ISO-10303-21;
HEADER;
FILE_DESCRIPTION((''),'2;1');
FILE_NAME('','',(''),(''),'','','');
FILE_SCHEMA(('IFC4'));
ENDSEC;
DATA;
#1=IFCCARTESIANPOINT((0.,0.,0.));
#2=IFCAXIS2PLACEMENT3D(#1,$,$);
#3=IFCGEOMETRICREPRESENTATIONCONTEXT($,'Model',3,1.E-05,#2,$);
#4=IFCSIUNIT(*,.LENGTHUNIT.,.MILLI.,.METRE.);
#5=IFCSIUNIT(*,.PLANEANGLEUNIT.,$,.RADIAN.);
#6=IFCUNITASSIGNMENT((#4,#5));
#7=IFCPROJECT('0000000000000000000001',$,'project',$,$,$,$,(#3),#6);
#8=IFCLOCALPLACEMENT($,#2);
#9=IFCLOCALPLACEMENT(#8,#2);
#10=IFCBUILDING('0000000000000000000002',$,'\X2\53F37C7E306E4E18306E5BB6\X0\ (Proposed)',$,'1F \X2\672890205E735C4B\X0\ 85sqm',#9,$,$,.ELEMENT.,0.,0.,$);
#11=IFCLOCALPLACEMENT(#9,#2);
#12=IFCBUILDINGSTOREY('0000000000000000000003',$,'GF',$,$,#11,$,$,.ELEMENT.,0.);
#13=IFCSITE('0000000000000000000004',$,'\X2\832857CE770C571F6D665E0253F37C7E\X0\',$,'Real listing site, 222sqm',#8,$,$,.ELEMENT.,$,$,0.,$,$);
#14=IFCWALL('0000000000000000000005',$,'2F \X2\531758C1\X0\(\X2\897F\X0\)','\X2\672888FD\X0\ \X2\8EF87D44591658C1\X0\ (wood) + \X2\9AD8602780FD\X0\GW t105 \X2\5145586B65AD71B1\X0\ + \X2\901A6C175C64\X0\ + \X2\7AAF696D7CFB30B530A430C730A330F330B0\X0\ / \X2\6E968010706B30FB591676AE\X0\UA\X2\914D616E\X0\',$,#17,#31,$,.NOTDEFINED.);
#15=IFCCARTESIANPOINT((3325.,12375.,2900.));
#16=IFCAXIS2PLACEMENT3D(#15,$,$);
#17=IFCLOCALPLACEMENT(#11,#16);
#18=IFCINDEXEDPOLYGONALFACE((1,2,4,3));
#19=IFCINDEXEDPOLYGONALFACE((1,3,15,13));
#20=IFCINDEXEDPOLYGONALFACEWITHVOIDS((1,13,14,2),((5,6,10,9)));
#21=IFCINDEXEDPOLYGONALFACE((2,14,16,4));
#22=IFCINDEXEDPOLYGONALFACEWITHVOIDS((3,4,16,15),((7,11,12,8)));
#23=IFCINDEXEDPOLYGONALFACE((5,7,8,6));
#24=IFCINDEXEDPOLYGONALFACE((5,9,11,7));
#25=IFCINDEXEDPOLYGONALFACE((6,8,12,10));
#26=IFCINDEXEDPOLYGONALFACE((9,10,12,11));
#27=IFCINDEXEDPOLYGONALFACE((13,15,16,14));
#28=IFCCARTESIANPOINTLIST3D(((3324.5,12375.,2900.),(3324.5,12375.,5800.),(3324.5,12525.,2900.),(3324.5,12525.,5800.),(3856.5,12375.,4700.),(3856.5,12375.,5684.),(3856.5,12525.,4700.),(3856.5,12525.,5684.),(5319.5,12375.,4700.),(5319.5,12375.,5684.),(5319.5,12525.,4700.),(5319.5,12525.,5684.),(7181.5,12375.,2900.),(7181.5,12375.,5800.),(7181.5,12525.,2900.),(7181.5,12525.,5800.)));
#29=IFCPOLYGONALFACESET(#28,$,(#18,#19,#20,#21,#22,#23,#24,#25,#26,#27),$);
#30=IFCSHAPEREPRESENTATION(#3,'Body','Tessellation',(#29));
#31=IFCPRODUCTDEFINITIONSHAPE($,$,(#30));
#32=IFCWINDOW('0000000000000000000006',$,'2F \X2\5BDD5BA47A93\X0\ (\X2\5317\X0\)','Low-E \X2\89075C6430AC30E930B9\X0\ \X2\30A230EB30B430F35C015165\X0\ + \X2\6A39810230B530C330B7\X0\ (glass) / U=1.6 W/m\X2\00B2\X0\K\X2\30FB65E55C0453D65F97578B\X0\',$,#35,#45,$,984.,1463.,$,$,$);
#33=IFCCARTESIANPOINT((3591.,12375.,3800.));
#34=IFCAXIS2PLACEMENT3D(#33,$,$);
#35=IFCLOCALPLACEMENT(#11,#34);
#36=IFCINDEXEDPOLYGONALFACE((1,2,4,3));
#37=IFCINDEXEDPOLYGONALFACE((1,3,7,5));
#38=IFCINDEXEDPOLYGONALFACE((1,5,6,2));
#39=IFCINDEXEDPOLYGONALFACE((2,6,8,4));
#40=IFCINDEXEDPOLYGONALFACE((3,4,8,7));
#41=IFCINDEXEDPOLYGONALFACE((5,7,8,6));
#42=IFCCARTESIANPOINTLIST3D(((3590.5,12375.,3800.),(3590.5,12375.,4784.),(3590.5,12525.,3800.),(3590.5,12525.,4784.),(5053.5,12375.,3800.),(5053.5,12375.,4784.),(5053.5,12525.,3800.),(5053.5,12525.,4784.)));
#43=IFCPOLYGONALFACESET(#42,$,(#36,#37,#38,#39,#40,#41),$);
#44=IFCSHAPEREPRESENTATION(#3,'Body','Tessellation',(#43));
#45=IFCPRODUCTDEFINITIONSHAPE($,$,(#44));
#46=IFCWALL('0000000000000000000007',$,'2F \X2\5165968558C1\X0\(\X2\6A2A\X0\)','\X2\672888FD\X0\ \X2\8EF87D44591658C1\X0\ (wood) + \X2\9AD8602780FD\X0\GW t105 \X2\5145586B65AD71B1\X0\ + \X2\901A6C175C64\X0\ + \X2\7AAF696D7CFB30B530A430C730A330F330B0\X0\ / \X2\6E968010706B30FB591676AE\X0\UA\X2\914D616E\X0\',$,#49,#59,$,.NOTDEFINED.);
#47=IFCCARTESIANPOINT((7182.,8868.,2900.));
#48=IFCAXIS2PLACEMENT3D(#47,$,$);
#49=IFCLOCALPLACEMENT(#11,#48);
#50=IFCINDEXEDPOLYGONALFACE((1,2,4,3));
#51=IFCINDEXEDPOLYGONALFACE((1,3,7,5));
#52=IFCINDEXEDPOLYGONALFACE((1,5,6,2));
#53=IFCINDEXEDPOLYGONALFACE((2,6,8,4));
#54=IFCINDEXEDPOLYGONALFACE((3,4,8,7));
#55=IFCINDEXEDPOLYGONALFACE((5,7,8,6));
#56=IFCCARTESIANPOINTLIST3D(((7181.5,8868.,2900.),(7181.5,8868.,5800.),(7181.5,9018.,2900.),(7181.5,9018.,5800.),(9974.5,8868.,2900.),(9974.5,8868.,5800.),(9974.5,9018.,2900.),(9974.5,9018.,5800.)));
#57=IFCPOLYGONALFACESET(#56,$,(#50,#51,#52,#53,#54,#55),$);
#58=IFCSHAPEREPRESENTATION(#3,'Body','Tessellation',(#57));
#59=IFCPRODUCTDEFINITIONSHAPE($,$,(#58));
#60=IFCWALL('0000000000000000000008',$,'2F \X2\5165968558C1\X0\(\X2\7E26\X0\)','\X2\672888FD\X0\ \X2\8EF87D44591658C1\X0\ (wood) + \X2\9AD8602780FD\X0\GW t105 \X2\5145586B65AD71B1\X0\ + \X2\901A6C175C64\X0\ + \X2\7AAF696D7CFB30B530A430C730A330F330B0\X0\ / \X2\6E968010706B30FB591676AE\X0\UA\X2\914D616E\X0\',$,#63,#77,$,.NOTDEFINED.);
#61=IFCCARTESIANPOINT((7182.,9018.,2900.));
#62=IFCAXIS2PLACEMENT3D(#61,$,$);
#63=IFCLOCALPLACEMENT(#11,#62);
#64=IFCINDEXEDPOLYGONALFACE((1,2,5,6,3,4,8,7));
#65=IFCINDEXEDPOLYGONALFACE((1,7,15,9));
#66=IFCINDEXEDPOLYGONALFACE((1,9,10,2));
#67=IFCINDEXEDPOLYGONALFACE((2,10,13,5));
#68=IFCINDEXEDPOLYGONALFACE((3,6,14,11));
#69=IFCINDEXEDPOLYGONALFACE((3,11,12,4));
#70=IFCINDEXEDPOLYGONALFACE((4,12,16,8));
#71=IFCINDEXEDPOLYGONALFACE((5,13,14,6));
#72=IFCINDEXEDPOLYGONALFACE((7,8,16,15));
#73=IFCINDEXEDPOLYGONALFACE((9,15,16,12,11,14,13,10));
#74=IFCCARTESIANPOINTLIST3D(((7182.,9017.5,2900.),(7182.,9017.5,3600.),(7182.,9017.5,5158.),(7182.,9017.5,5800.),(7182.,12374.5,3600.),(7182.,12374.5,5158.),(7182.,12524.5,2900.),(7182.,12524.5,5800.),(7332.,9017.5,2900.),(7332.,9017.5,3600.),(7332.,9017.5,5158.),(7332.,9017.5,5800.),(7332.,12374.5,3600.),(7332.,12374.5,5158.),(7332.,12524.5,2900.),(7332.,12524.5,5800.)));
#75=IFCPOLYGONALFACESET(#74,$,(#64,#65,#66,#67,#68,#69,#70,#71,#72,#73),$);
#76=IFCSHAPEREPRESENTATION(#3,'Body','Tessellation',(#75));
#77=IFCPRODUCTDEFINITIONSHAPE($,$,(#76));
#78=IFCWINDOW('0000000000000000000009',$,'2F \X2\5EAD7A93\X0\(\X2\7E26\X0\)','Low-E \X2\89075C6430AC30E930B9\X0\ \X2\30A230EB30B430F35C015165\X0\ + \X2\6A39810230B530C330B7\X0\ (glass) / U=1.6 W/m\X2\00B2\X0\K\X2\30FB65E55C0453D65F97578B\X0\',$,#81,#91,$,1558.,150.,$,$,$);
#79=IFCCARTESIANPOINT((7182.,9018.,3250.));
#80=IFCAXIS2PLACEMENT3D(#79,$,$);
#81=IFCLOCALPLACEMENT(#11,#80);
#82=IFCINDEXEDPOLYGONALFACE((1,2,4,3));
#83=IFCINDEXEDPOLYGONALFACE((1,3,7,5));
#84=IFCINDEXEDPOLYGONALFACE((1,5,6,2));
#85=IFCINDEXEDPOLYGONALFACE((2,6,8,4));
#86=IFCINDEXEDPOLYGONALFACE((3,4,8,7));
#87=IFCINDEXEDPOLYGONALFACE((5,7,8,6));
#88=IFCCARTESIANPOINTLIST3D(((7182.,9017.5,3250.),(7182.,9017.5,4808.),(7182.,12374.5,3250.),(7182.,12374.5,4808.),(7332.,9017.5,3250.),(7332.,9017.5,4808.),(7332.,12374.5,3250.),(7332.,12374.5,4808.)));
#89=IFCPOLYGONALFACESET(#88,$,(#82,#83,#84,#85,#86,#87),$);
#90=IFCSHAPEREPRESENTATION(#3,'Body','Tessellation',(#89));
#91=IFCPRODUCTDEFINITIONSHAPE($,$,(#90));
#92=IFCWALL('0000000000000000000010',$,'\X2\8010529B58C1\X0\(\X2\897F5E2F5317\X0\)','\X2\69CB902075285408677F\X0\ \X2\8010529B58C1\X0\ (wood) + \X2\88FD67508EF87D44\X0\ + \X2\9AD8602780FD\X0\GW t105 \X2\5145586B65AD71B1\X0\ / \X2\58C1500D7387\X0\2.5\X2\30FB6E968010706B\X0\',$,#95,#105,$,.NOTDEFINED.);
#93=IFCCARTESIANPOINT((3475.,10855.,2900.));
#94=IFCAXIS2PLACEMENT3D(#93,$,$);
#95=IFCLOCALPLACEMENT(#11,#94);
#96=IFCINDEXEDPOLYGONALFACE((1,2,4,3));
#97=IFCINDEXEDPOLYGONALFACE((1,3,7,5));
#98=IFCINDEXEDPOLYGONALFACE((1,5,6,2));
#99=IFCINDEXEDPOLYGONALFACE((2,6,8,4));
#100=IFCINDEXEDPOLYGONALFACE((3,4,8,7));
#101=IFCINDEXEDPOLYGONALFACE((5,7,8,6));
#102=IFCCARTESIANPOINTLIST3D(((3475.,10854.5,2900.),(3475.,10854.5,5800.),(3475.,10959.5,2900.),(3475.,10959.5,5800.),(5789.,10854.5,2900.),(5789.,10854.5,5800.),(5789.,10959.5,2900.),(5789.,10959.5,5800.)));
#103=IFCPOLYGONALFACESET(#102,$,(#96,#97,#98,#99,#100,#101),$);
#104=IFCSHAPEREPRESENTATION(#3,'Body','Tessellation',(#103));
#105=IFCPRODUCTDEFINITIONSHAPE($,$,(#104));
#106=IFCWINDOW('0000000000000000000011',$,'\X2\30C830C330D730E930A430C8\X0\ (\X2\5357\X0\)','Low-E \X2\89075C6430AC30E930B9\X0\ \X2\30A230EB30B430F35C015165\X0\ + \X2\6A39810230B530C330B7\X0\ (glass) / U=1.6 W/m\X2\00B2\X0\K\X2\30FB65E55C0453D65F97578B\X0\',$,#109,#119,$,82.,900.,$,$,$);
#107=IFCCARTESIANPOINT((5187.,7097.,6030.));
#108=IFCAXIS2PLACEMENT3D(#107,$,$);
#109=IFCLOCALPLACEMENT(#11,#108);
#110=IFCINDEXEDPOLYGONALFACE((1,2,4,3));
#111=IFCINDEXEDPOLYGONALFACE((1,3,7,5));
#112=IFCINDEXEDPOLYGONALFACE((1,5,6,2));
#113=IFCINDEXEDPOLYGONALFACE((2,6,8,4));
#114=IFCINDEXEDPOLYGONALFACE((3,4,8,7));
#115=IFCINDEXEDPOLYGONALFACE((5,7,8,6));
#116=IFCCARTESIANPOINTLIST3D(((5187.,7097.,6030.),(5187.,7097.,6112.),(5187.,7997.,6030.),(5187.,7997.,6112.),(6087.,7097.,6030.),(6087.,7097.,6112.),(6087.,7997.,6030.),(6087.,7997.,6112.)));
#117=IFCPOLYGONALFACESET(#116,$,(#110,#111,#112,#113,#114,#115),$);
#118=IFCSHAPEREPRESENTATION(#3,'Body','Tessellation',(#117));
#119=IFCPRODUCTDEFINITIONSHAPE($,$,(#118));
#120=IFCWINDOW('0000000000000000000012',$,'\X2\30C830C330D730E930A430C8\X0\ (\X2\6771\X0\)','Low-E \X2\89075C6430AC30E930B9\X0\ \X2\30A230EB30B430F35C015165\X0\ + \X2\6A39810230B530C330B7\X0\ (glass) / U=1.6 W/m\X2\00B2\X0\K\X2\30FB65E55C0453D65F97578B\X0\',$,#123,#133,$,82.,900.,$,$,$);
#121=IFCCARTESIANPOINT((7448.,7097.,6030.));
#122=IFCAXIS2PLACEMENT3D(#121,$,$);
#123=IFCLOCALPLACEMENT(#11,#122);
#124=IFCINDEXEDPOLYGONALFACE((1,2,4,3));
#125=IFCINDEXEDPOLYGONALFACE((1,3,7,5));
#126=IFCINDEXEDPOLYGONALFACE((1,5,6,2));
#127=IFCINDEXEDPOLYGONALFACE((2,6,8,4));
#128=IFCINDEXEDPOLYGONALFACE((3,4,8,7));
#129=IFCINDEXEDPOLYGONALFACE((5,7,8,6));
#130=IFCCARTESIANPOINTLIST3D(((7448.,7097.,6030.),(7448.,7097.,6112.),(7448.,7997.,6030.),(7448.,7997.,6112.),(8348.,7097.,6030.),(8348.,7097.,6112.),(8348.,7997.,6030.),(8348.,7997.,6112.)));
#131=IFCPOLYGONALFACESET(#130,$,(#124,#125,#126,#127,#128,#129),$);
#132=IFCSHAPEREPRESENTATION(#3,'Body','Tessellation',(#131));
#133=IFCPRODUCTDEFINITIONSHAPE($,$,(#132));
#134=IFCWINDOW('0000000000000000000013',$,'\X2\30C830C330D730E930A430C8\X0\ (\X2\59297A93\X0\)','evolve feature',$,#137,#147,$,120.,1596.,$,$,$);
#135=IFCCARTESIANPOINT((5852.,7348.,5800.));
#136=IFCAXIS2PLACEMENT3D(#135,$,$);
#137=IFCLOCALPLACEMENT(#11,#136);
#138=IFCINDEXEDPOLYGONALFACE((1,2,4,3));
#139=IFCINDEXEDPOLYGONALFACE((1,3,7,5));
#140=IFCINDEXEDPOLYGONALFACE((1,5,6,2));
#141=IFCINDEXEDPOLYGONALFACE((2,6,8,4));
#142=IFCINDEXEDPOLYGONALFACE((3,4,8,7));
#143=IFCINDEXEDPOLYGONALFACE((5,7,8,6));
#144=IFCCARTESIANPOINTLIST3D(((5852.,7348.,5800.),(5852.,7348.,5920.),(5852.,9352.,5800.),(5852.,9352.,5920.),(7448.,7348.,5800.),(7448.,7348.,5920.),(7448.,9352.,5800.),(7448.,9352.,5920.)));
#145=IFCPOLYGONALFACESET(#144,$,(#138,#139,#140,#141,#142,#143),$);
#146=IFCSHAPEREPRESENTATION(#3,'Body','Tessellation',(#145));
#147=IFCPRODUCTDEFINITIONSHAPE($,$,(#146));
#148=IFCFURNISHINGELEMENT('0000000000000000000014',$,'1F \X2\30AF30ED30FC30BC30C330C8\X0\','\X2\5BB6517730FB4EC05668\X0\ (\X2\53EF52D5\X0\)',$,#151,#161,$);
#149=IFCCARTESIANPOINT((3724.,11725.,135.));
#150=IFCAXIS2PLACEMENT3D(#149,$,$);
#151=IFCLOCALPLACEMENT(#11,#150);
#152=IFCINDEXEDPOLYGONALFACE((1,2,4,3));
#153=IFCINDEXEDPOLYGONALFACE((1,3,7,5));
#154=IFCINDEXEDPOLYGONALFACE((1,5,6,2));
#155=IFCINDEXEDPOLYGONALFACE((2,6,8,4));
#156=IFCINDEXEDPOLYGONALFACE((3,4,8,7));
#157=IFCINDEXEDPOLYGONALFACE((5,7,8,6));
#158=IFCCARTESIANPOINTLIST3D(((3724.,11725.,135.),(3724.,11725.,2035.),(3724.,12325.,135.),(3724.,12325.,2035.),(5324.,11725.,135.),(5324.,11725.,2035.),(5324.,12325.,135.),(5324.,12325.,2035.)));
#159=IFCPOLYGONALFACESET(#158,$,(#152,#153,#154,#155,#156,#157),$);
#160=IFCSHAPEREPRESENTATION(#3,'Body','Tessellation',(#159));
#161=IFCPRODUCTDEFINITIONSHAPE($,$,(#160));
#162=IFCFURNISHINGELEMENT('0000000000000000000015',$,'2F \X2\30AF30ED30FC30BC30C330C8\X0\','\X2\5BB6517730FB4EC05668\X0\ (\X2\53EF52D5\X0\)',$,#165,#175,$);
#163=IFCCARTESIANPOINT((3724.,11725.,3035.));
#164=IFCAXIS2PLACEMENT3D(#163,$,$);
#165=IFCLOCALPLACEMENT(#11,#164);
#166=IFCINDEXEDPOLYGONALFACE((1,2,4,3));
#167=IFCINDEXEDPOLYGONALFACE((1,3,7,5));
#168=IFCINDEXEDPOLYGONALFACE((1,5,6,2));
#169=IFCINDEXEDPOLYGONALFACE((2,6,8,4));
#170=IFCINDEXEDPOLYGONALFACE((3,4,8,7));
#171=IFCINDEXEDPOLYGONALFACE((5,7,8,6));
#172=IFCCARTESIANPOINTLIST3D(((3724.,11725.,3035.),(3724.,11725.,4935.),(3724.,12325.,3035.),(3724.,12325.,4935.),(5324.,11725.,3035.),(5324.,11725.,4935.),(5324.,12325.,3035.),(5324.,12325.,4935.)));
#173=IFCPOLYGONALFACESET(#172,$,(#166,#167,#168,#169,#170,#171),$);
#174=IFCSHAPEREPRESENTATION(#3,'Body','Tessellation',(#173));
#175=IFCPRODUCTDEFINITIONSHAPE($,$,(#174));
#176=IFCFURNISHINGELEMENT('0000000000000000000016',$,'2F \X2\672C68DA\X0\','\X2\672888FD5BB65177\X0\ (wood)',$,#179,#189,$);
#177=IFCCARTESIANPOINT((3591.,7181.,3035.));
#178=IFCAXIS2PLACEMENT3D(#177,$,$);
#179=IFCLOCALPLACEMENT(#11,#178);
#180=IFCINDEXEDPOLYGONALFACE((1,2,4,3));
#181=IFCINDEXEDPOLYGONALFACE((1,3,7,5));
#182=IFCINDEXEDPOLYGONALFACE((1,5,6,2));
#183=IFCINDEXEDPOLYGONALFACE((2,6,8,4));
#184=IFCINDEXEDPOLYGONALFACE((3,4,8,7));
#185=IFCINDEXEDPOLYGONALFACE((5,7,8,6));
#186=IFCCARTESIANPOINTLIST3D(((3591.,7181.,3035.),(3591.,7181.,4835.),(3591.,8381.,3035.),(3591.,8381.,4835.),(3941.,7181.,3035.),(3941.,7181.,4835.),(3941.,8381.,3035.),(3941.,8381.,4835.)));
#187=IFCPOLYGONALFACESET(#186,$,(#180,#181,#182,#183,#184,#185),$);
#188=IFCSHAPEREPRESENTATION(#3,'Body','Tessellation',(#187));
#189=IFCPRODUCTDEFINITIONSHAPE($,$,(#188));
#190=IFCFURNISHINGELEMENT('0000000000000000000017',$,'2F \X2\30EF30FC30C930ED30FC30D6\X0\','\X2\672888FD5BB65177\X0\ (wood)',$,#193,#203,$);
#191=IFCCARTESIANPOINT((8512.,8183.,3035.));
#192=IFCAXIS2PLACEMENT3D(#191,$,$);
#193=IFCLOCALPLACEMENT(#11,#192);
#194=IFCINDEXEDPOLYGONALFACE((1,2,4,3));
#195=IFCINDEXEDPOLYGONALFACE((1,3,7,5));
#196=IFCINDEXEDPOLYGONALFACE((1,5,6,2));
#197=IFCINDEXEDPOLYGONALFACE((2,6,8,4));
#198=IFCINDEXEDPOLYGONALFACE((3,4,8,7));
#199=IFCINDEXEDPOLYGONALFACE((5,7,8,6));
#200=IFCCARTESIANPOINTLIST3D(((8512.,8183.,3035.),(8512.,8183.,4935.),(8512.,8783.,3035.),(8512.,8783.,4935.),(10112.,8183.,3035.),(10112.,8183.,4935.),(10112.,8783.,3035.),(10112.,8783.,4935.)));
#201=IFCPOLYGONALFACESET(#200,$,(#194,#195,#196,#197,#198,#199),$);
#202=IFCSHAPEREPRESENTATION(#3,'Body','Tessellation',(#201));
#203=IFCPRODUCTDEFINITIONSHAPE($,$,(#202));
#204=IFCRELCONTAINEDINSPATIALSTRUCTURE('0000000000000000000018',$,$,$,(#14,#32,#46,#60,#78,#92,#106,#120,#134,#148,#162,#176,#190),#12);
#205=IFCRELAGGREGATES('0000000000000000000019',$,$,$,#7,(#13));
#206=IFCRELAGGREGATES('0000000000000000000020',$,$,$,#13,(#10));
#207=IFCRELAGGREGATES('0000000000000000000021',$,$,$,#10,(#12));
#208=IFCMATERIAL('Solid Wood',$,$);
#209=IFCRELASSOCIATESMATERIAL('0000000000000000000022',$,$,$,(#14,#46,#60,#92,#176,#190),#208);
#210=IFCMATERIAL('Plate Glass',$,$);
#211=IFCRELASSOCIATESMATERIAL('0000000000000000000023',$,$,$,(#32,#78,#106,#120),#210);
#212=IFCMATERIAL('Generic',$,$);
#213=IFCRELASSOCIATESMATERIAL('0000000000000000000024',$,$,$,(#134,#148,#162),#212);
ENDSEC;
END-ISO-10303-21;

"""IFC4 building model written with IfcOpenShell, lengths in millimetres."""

from ifc_helpers import new_model, si_unit, frame, frame_2d, origin, place, context, project, spatial, rectangle, extrude, material, element, fill, save


model = new_model("IFC4")

# Units and contexts
model_context = context("Model", 3, precision=1e-05, world=origin())
ifc_project = project(units=[si_unit("LENGTHUNIT", "METRE", prefix="MILLI"), si_unit("PLANEANGLEUNIT", "RADIAN")], contexts=[model_context])

# Site, building, storey
site_placement = place(None, origin())
site = spatial("IfcSite", under=ifc_project, at=site_placement, Name="茨城県土浦市右籾", ObjectType="Real listing site, 222sqm", CompositionType="ELEMENT", RefElevation=0.0)
building_placement = place(site_placement, origin())
building = spatial("IfcBuilding", under=site, at=building_placement, Name="右籾の丘の家 (Proposed)", ObjectType="1F 木造平屋 85sqm", CompositionType="ELEMENT", ElevationOfRefHeight=0.0, ElevationOfTerrain=0.0)
storey_placement = place(building_placement, origin())
storey = spatial("IfcBuildingStorey", under=building, at=storey_placement, Name="GF", CompositionType="ELEMENT", Elevation=0.0)

# Shared definitions
ifc_material_1 = material(Name="Solid Wood")

# Wall, opening, window
wall_1_placement = place(storey_placement, frame((3325.0, 12375.0, 2900.0)))
wall_1 = element("IfcWall", 1, at=wall_1_placement, inside=storey, material=ifc_material_1, Name="2F 北壁(西)", Description="木製 軸組外壁 (wood) + 高性能GW t105 充填断熱 + 通気層 + 窯業系サイディング / 準耐火・外皮UA配慮", PredefinedType="NOTDEFINED", context=model_context, shape_type="SweptSolid", body=[
    extrude(rectangle(XDim=3857.0, YDim=150.0, at=frame_2d((1928.0, 75.0))), frame((3325.0, 12375.0, 2900.0)), (0.0, 0.0, 1.0), 2900.0),
])
opening_1_placement = place(storey_placement, frame((3591.0, 12375.0, 3800.0)))
opening_1 = element("IfcOpeningElement", 2, at=opening_1_placement, cuts=wall_1, PredefinedType="NOTDEFINED", context=model_context, shape_type="SweptSolid", body=[
    extrude(rectangle(XDim=1463.0, YDim=150.0, at=frame_2d((731.0, 75.0))), frame((3591.0, 12375.0, 3800.0)), (0.0, 0.0, 1.0), 984.0),
])
ifc_material_2 = material(Name="Plate Glass")
window_1_placement = place(storey_placement, frame((3591.0, 12375.0, 3800.0)))
window_1 = element("IfcWindow", 3, at=window_1_placement, inside=storey, material=ifc_material_2, Name="2F 寝室窓 (北)", Description="Low-E 複層ガラス アルゴン封入 + 樹脂サッシ (glass) / U=1.6 W/m²K・日射取得型", OverallHeight=984.0, OverallWidth=1463.0, context=model_context, shape_type="SweptSolid", body=[
    extrude(rectangle(XDim=1463.0, YDim=150.0, at=frame_2d((731.0, 75.0))), frame((3591.0, 12375.0, 3800.0)), (0.0, 0.0, 1.0), 984.0),
])
fill(opening_1, window_1)

# Wall
wall_2_placement = place(storey_placement, frame((7182.0, 8868.0, 2900.0)))
element("IfcWall", 4, at=wall_2_placement, inside=storey, material=ifc_material_1, Name="2F 入隅壁(横)", Description="木製 軸組外壁 (wood) + 高性能GW t105 充填断熱 + 通気層 + 窯業系サイディング / 準耐火・外皮UA配慮", PredefinedType="NOTDEFINED", context=model_context, shape_type="SweptSolid", body=[
    extrude(rectangle(XDim=2793.0, YDim=150.0, at=frame_2d((1396.0, 75.0))), frame((7182.0, 8868.0, 2900.0)), (0.0, 0.0, 1.0), 2900.0),
])

# Wall, opening, window
wall_3_placement = place(storey_placement, frame((7182.0, 9018.0, 2900.0)))
wall_3 = element("IfcWall", 5, at=wall_3_placement, inside=storey, material=ifc_material_1, Name="2F 入隅壁(縦)", Description="木製 軸組外壁 (wood) + 高性能GW t105 充填断熱 + 通気層 + 窯業系サイディング / 準耐火・外皮UA配慮", PredefinedType="NOTDEFINED", context=model_context, shape_type="SweptSolid", body=[
    extrude(rectangle(XDim=150.0, YDim=3507.0, at=frame_2d((75.0, 1753.0))), frame((7182.0, 9018.0, 2900.0)), (0.0, 0.0, 1.0), 2900.0),
])
opening_2_placement = place(storey_placement, frame((7182.0, 9018.0, 3250.0)))
opening_2 = element("IfcOpeningElement", 6, at=opening_2_placement, cuts=wall_3, PredefinedType="NOTDEFINED", context=model_context, shape_type="SweptSolid", body=[
    extrude(rectangle(XDim=150.0, YDim=3357.0, at=frame_2d((75.0, 1678.0))), frame((7182.0, 9018.0, 3250.0)), (0.0, 0.0, 1.0), 1558.0),
])
window_2_placement = place(storey_placement, frame((7182.0, 9018.0, 3250.0)))
window_2 = element("IfcWindow", 7, at=window_2_placement, inside=storey, material=ifc_material_2, Name="2F 庭窓(縦)", Description="Low-E 複層ガラス アルゴン封入 + 樹脂サッシ (glass) / U=1.6 W/m²K・日射取得型", OverallHeight=1558.0, OverallWidth=150.0, context=model_context, shape_type="SweptSolid", body=[
    extrude(rectangle(XDim=150.0, YDim=3357.0, at=frame_2d((75.0, 1678.0))), frame((7182.0, 9018.0, 3250.0)), (0.0, 0.0, 1.0), 1558.0),
])
fill(opening_2, window_2)

# Wall
wall_4_placement = place(storey_placement, frame((3475.0, 10855.0, 2900.0)))
element("IfcWall", 8, at=wall_4_placement, inside=storey, material=ifc_material_1, Name="耐力壁(西帯北)", Description="構造用合板 耐力壁 (wood) + 製材軸組 + 高性能GW t105 充填断熱 / 壁倍率2.5・準耐火", PredefinedType="NOTDEFINED", context=model_context, shape_type="SweptSolid", body=[
    extrude(rectangle(XDim=2314.0, YDim=105.0, at=frame_2d((1157.0, 52.0))), frame((3475.0, 10855.0, 2900.0)), (0.0, 0.0, 1.0), 2900.0),
])

# Windows
window_3_placement = place(storey_placement, frame((5187.0, 7097.0, 6030.0)))
element("IfcWindow", 9, at=window_3_placement, inside=storey, material=ifc_material_2, Name="トップライト (南)", Description="Low-E 複層ガラス アルゴン封入 + 樹脂サッシ (glass) / U=1.6 W/m²K・日射取得型", OverallHeight=82.0, OverallWidth=900.0, context=model_context, shape_type="SweptSolid", body=[
    extrude(rectangle(XDim=900.0, YDim=900.0, at=frame_2d((450.0, 450.0))), frame((5187.0, 7097.0, 6030.0)), (0.0, 0.0, 1.0), 82.0),
])
window_4_placement = place(storey_placement, frame((7448.0, 7097.0, 6030.0)))
element("IfcWindow", 10, at=window_4_placement, inside=storey, material=ifc_material_2, Name="トップライト (東)", Description="Low-E 複層ガラス アルゴン封入 + 樹脂サッシ (glass) / U=1.6 W/m²K・日射取得型", OverallHeight=82.0, OverallWidth=900.0, context=model_context, shape_type="SweptSolid", body=[
    extrude(rectangle(XDim=900.0, YDim=900.0, at=frame_2d((450.0, 450.0))), frame((7448.0, 7097.0, 6030.0)), (0.0, 0.0, 1.0), 82.0),
])
ifc_material_3 = material(Name="Generic")
window_5_placement = place(storey_placement, frame((5852.0, 7348.0, 5800.0)))
element("IfcWindow", 11, at=window_5_placement, inside=storey, material=ifc_material_3, Name="トップライト (天窓)", Description="evolve feature", OverallHeight=120.0, OverallWidth=1596.0, context=model_context, shape_type="SweptSolid", body=[
    extrude(rectangle(XDim=1596.0, YDim=2004.0, at=frame_2d((798.0, 1002.0))), frame((5852.0, 7348.0, 5800.0)), (0.0, 0.0, 1.0), 120.0),
])

# Furnishing elements
furnishing_1_placement = place(storey_placement, frame((3724.0, 11725.0, 135.0)))
element("IfcFurnishingElement", 12, at=furnishing_1_placement, inside=storey, material=ifc_material_3, Name="1F クローゼット", Description="家具・什器 (可動)", context=model_context, shape_type="SweptSolid", body=[
    extrude(rectangle(XDim=1600.0, YDim=600.0, at=frame_2d((800.0, 300.0))), frame((3724.0, 11725.0, 135.0)), (0.0, 0.0, 1.0), 1900.0),
])
furnishing_2_placement = place(storey_placement, frame((3724.0, 11725.0, 3035.0)))
element("IfcFurnishingElement", 13, at=furnishing_2_placement, inside=storey, material=ifc_material_3, Name="2F クローゼット", Description="家具・什器 (可動)", context=model_context, shape_type="SweptSolid", body=[
    extrude(rectangle(XDim=1600.0, YDim=600.0, at=frame_2d((800.0, 300.0))), frame((3724.0, 11725.0, 3035.0)), (0.0, 0.0, 1.0), 1900.0),
])
furnishing_3_placement = place(storey_placement, frame((3591.0, 7181.0, 3035.0)))
element("IfcFurnishingElement", 14, at=furnishing_3_placement, inside=storey, material=ifc_material_1, Name="2F 本棚", Description="木製家具 (wood)", context=model_context, shape_type="SweptSolid", body=[
    extrude(rectangle(XDim=350.0, YDim=1200.0, at=frame_2d((175.0, 600.0))), frame((3591.0, 7181.0, 3035.0)), (0.0, 0.0, 1.0), 1800.0),
])
furnishing_4_placement = place(storey_placement, frame((8512.0, 8183.0, 3035.0)))
element("IfcFurnishingElement", 15, at=furnishing_4_placement, inside=storey, material=ifc_material_1, Name="2F ワードローブ", Description="木製家具 (wood)", context=model_context, shape_type="SweptSolid", body=[
    extrude(rectangle(XDim=1600.0, YDim=600.0, at=frame_2d((800.0, 300.0))), frame((8512.0, 8183.0, 3035.0)), (0.0, 0.0, 1.0), 1900.0),
])

save(model, "model.ifc")
